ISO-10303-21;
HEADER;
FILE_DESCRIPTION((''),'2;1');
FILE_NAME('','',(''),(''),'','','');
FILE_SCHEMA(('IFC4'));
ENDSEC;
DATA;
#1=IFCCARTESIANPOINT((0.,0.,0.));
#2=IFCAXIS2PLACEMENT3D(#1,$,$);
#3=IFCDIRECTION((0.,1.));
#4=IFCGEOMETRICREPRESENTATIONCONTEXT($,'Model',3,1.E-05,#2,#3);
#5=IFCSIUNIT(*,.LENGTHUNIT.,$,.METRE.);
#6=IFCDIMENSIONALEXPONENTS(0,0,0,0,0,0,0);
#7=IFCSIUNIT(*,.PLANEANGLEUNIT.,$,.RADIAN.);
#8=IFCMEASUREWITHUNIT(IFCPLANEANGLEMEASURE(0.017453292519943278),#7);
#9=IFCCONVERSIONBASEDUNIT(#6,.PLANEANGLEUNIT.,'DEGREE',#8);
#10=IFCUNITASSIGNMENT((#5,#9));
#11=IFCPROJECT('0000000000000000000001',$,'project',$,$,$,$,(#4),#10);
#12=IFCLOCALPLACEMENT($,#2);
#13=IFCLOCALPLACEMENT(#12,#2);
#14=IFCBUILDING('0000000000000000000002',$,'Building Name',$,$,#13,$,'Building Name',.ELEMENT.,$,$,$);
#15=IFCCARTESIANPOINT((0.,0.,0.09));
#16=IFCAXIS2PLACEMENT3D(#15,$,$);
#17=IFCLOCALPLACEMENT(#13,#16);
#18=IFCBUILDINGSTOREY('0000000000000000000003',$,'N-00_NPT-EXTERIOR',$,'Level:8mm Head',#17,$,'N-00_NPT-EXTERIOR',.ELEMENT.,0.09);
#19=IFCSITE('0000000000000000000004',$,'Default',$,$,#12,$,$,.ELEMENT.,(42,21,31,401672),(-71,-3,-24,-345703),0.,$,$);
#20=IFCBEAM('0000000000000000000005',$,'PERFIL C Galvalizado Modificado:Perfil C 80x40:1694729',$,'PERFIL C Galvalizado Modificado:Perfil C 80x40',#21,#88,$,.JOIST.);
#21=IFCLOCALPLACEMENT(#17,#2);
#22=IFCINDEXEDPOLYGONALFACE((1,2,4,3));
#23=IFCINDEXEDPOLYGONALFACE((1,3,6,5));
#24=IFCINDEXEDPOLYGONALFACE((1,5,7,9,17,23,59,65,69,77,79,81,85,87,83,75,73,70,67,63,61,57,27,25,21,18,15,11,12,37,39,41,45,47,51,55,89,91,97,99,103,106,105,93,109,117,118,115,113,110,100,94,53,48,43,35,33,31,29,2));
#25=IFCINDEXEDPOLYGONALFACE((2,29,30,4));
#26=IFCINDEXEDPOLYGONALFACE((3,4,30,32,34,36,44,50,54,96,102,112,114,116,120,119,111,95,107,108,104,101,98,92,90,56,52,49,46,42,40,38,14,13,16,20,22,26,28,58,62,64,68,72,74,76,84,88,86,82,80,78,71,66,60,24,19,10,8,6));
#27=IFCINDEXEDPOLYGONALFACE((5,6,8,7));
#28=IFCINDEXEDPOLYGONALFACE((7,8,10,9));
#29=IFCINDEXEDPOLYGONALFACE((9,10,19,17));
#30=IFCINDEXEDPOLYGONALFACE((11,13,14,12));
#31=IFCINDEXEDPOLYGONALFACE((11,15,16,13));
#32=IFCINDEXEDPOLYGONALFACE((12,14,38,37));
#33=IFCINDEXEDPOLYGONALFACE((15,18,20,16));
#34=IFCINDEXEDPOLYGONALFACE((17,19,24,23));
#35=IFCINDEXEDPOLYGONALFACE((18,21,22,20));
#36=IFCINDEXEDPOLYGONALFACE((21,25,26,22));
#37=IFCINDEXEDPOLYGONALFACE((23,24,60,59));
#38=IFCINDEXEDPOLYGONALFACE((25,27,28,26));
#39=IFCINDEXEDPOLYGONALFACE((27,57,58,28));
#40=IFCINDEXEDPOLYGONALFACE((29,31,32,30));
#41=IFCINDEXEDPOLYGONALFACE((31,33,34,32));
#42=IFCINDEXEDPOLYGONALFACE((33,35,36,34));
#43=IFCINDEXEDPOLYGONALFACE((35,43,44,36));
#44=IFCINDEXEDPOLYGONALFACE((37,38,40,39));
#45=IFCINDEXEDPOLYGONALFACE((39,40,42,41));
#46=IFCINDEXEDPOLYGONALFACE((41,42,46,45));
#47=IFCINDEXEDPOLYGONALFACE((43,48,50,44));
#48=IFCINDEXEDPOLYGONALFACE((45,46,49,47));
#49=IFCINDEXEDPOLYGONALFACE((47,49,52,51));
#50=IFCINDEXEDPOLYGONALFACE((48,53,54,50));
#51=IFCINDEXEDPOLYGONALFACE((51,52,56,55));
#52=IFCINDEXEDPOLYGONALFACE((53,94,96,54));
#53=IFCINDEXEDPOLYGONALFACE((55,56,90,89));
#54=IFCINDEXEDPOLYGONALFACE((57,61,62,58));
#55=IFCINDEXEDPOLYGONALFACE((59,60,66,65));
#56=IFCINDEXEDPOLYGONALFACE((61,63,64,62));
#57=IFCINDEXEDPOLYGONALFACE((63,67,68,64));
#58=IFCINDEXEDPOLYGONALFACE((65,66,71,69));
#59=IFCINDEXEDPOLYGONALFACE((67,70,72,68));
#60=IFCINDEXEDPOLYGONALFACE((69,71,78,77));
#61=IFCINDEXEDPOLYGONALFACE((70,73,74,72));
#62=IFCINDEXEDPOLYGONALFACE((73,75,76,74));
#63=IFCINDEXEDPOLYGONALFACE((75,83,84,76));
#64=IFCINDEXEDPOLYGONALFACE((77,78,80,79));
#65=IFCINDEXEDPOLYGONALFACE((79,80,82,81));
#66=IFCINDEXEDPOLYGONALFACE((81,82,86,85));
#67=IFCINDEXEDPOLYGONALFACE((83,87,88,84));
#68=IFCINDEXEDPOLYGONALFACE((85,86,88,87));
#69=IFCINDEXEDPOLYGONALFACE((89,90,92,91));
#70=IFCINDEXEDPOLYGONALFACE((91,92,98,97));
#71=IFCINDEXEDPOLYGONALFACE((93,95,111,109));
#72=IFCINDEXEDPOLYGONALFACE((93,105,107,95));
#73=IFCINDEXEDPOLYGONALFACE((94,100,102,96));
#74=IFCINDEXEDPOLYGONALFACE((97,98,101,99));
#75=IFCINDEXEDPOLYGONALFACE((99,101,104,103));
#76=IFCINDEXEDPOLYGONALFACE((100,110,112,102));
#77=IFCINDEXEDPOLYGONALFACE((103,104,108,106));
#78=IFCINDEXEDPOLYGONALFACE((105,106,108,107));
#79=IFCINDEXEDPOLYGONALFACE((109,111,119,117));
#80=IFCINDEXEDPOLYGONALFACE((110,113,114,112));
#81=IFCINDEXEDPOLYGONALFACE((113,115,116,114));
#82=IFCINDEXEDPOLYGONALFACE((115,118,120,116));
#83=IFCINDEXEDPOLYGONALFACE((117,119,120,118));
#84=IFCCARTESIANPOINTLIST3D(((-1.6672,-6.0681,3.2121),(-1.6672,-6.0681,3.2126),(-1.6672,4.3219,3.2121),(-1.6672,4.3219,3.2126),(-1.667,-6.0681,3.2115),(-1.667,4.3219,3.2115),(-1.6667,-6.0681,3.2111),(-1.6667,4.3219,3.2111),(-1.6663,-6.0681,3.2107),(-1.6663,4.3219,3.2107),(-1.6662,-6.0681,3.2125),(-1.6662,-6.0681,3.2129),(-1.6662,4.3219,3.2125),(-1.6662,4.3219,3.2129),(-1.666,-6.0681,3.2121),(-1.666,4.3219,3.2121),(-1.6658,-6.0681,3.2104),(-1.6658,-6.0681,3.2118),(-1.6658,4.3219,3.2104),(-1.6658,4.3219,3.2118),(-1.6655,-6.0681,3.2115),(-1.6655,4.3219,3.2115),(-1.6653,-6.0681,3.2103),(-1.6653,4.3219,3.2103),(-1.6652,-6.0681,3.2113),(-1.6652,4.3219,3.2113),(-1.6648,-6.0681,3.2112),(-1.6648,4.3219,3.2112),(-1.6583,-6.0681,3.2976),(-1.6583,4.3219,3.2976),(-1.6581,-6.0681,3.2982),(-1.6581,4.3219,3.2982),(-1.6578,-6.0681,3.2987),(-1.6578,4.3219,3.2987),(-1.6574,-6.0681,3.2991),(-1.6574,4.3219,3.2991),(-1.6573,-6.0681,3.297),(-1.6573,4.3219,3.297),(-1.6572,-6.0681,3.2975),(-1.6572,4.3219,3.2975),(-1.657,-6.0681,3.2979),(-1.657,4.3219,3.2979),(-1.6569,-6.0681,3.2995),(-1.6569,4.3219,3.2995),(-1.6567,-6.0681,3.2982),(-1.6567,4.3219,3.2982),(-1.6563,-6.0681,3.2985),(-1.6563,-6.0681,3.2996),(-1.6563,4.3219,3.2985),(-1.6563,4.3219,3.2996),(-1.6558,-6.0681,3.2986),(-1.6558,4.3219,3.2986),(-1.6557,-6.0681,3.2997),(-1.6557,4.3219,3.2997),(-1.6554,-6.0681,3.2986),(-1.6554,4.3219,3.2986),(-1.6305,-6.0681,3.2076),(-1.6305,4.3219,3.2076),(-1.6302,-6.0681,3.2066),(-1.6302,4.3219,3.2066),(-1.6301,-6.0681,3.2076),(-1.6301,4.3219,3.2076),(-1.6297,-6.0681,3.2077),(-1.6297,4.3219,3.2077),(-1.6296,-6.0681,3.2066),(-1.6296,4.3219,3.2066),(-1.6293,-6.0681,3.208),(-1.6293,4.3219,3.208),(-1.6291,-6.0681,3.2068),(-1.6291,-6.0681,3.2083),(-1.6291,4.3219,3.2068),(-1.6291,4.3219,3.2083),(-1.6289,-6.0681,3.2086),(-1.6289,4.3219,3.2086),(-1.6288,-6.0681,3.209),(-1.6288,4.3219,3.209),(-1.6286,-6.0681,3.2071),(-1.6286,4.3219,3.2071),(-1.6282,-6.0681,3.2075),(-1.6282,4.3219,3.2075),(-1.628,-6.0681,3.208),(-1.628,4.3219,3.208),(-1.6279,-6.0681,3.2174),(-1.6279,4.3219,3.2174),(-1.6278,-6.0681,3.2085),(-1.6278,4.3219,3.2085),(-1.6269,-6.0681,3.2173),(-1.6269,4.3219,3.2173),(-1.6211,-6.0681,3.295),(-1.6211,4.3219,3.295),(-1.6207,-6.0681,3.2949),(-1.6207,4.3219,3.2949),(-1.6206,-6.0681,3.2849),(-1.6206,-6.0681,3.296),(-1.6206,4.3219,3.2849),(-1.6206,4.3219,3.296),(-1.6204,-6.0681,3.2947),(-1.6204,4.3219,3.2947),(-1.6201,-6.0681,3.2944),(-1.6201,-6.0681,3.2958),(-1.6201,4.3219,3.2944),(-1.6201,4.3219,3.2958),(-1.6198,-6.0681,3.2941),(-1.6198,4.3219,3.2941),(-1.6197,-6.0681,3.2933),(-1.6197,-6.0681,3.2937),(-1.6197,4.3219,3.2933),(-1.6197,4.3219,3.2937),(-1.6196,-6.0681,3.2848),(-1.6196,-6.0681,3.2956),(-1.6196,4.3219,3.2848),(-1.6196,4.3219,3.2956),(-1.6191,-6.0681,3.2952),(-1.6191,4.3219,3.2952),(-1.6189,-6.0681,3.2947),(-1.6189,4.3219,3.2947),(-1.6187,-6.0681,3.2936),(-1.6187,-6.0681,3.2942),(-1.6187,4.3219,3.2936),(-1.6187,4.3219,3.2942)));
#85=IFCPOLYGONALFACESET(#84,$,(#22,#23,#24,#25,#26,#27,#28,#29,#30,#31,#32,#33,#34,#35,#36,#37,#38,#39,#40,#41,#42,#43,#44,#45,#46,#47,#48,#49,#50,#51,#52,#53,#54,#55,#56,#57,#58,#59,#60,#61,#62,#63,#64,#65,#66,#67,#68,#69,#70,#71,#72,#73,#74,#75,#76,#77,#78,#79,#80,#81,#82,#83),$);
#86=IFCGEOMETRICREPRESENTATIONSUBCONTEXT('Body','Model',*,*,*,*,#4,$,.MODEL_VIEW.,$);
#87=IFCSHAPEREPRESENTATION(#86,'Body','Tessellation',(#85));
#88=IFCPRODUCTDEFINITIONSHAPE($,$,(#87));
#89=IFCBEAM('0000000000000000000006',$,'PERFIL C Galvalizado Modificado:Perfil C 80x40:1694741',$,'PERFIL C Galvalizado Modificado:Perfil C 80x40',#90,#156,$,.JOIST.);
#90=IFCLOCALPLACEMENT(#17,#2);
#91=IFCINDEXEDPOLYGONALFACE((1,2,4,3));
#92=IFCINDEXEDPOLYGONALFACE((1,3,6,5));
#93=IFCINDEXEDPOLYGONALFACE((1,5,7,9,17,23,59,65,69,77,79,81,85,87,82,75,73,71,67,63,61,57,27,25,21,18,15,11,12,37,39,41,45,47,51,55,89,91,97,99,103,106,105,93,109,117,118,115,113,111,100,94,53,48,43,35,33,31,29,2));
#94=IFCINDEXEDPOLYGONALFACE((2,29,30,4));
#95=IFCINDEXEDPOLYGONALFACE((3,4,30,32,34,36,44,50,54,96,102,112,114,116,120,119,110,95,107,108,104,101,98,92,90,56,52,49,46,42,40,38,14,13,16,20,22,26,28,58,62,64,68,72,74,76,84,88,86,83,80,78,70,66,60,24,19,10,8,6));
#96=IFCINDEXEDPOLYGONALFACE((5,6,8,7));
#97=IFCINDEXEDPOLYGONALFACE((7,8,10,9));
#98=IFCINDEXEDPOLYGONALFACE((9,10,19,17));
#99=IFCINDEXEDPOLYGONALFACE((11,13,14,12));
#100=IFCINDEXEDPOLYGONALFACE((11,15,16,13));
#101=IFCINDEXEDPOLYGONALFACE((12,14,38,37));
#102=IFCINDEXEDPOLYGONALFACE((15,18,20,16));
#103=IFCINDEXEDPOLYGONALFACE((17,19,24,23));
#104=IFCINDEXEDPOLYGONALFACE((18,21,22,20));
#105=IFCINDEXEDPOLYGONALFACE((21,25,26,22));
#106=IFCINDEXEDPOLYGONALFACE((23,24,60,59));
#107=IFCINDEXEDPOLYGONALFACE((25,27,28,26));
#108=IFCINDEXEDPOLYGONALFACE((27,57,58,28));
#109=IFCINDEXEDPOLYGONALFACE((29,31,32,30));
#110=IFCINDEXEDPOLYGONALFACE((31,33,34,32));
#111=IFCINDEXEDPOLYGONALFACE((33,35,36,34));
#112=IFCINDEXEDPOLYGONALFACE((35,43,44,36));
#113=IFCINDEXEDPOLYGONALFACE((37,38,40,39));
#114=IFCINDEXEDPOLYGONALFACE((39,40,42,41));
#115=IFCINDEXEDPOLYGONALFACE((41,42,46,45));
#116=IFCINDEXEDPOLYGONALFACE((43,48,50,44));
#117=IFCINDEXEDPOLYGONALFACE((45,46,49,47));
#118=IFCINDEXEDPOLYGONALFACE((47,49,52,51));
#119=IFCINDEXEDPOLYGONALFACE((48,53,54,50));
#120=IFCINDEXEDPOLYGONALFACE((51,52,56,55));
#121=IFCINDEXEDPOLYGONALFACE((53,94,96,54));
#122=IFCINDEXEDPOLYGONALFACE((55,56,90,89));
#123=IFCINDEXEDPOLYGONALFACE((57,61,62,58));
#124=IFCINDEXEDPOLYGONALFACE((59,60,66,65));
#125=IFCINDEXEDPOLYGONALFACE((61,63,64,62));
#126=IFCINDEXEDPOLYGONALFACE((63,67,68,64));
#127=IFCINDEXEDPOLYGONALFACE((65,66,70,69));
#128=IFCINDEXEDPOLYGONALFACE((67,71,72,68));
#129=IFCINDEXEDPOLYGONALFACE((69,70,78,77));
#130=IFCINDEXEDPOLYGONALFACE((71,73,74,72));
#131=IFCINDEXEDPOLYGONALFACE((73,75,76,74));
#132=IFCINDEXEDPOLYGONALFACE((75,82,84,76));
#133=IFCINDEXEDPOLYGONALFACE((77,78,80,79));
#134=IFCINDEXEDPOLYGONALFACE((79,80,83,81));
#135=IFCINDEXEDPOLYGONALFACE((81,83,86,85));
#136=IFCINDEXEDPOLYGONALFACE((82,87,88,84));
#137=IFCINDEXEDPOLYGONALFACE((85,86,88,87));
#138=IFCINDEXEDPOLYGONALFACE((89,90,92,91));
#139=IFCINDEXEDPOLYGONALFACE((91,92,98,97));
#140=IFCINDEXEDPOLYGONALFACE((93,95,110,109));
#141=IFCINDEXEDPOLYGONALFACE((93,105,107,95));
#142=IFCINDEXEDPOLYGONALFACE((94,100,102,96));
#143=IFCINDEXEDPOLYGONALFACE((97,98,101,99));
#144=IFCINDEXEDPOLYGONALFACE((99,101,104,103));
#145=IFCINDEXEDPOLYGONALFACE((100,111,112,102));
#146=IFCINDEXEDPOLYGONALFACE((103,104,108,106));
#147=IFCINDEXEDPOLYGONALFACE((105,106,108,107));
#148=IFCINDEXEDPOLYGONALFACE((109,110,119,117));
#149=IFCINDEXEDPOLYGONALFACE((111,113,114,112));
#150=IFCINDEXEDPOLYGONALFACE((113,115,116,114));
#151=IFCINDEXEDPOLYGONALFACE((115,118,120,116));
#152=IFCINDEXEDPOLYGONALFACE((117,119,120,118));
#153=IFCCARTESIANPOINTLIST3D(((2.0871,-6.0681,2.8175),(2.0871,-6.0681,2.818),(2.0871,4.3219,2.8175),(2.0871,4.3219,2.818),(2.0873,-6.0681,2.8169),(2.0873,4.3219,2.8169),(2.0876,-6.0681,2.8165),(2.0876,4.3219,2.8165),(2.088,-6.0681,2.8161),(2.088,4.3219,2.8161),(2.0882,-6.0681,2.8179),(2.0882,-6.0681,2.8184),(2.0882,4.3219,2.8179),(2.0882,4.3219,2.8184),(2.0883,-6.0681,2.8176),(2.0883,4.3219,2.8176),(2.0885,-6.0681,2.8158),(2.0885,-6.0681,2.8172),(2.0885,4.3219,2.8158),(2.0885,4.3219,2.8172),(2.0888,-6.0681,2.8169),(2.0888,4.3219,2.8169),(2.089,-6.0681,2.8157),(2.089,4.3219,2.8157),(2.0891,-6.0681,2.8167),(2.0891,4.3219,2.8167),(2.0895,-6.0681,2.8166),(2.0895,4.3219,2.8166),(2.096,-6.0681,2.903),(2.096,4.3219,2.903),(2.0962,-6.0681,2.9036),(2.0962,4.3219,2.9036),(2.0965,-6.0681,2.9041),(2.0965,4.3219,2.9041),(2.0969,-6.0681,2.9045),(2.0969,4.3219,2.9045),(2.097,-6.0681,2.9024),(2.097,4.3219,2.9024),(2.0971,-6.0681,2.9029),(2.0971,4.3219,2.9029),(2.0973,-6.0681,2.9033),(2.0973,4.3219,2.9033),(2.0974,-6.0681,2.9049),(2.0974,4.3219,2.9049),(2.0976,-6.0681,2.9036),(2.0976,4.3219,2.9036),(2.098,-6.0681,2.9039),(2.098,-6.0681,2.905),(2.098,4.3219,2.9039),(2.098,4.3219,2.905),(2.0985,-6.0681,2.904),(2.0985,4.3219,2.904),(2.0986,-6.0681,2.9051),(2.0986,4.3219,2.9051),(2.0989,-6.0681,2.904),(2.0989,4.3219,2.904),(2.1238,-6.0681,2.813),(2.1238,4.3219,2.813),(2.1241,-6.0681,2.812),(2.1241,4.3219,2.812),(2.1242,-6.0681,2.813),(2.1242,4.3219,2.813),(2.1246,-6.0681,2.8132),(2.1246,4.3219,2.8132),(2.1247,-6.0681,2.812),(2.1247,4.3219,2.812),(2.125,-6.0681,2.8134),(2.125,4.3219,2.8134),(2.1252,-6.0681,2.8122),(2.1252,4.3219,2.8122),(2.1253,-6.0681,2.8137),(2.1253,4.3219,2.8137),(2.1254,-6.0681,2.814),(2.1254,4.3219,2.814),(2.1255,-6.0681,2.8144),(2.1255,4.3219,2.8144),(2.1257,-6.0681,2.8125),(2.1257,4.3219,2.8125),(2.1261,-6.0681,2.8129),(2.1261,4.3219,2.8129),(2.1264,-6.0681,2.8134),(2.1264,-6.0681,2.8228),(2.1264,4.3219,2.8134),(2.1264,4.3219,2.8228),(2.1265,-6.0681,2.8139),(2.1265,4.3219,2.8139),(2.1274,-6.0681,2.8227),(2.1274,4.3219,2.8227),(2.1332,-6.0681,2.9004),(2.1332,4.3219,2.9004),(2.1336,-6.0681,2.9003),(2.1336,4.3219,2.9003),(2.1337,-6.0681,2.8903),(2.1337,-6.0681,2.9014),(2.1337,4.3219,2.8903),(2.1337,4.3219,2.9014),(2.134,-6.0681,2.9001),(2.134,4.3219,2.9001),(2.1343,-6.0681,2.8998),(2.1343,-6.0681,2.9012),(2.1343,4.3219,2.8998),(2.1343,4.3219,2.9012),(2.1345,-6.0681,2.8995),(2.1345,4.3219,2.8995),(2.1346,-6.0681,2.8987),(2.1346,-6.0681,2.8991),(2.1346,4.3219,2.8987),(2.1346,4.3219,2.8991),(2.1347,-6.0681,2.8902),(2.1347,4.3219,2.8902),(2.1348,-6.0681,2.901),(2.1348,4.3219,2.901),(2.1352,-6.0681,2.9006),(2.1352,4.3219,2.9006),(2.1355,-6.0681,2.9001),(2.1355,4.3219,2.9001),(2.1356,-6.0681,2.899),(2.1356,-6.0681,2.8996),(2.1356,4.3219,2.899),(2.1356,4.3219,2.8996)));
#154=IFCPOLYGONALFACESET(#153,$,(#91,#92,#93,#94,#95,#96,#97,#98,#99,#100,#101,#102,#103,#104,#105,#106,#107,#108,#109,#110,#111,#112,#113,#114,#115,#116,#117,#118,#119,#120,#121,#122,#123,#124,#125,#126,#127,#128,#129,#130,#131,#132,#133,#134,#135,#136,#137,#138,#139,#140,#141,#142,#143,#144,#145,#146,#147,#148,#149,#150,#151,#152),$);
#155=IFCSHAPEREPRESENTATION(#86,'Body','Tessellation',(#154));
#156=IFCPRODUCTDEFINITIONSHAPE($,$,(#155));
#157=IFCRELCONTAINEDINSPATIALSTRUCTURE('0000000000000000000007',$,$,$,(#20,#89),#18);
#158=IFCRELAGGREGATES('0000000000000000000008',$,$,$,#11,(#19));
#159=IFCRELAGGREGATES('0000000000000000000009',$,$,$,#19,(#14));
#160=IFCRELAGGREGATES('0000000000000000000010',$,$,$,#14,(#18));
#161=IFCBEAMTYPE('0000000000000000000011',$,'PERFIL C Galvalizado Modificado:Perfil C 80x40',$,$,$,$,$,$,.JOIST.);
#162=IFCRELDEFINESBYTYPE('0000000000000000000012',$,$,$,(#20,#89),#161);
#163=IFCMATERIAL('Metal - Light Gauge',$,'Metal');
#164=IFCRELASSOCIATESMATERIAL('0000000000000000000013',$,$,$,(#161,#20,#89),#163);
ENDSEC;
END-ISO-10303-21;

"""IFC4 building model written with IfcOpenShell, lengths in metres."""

from ifc_helpers import new_model, entity, si_unit, converted_unit, direction, frame, origin, place, context, subcontext, project, spatial, line, arc, indexed_curve, outline, extrude, source, transform, mapped, material, type_object, type_shapes, element, save


model = new_model("IFC4")

# Units and contexts
model_context = context("Model", 3, precision=1e-05, world=origin(), true_north=direction((0.0, 1.0)))
body_context = subcontext(model_context, "Body", "Model", "MODEL_VIEW")
ifc_project = project(units=[si_unit("LENGTHUNIT", "METRE"), converted_unit("PLANEANGLEUNIT", "DEGREE", entity("IfcPlaneAngleMeasure", 0.017453292519943278), si_unit("PLANEANGLEUNIT", "RADIAN"), dimensions=[0, 0, 0, 0, 0, 0, 0])], contexts=[model_context])

# Site, building, storey
site_placement = place(None, origin())
site = spatial("IfcSite", under=ifc_project, at=site_placement, Name="Default", CompositionType="ELEMENT", RefLatitude=(42, 21, 31, 401672), RefLongitude=(-71, -3, -24, -345703), RefElevation=0.0)
building_placement = place(site_placement, origin())
building = spatial("IfcBuilding", under=site, at=building_placement, Name="Building Name", LongName="Building Name", CompositionType="ELEMENT")
storey_placement = place(building_placement, frame((0.0, 0.0, 0.09)))
storey = spatial("IfcBuildingStorey", under=building, at=storey_placement, Name="N-00_NPT-EXTERIOR", ObjectType="Level:8mm Head", LongName="N-00_NPT-EXTERIOR", CompositionType="ELEMENT", Elevation=0.09)

# Beams
ifc_material_1 = material(Name="Metal - Light Gauge", Category="Metal")
beam_type_1 = type_object("IfcBeamType", Name="PERFIL C Galvalizado Modificado:Perfil C 80x40", PredefinedType="JOIST", material=ifc_material_1)
shared_shape_1 = source(origin(), body_context, "Body", "SweptSolid", [
    extrude(outline(indexed_curve([(-0.0428, -0.0237), (0.0426, -0.0237), (0.0443, -0.023), (0.045, -0.0214), (0.045, 0.0139), (0.0443, 0.0154), (0.0428, 0.0161), (0.034, 0.0161), (0.034, 0.0151), (0.0424, 0.0151), (0.0435, 0.0146), (0.044, 0.0135), (0.044, -0.021), (0.0435, -0.0222), (0.0422, -0.0227), (-0.0424, -0.0227), (-0.0435, -0.0223), (-0.0439, -0.0212), (-0.0439, 0.0133), (-0.0435, 0.0144), (-0.0424, 0.0149), (-0.0339, 0.0149), (-0.0339, 0.0159), (-0.0428, 0.0159), (-0.0443, 0.0152), (-0.0449, 0.0137), (-0.0449, -0.0216), (-0.0443, -0.0231)], segments=[line(1, 2), arc(2, 3, 4), line(4, 5), arc(5, 6, 7), line(7, 8, 9, 10), arc(10, 11, 12), line(12, 13), arc(13, 14, 15), line(15, 16), arc(16, 17, 18), line(18, 19), arc(19, 20, 21), line(21, 22, 23, 24), arc(24, 25, 26), line(26, 27), arc(27, 28, 1)], self_intersect=False)), frame((-5.195, -0.0037, 0.0), z_axis=(1.0, 0.0, 0.0), x_axis=(0.0, 0.0, 1.0)), (0.0, 0.0, 1.0), 10.39),
])
type_shapes(beam_type_1, [shared_shape_1])
for number, where, z_axis, x_axis, name in (
    (1, (-1.6428, -0.8731, 3.2531), (0.104528, 0.0, 0.994522), (0.0, 1.0, 0.0), "PERFIL C Galvalizado Modificado:Perfil C 80x40:1694729"),
    (2, (2.1115, -0.8731, 2.8585), (0.104528, 0.0, 0.994522), (0.0, 1.0, 0.0), "PERFIL C Galvalizado Modificado:Perfil C 80x40:1694741"),
):
    element("IfcBeam", number, at=place(storey_placement, frame(where, z_axis=z_axis, x_axis=x_axis)), inside=storey, type_object=beam_type_1, material=ifc_material_1, Name=name, ObjectType="PERFIL C Galvalizado Modificado:Perfil C 80x40", PredefinedType="JOIST", context=body_context, shape_type="MappedRepresentation", body=[
        mapped(shared_shape_1, transform((0.0, 0.0, 0.0), scale=1.0)),
    ])

save(model, "model.ifc")
